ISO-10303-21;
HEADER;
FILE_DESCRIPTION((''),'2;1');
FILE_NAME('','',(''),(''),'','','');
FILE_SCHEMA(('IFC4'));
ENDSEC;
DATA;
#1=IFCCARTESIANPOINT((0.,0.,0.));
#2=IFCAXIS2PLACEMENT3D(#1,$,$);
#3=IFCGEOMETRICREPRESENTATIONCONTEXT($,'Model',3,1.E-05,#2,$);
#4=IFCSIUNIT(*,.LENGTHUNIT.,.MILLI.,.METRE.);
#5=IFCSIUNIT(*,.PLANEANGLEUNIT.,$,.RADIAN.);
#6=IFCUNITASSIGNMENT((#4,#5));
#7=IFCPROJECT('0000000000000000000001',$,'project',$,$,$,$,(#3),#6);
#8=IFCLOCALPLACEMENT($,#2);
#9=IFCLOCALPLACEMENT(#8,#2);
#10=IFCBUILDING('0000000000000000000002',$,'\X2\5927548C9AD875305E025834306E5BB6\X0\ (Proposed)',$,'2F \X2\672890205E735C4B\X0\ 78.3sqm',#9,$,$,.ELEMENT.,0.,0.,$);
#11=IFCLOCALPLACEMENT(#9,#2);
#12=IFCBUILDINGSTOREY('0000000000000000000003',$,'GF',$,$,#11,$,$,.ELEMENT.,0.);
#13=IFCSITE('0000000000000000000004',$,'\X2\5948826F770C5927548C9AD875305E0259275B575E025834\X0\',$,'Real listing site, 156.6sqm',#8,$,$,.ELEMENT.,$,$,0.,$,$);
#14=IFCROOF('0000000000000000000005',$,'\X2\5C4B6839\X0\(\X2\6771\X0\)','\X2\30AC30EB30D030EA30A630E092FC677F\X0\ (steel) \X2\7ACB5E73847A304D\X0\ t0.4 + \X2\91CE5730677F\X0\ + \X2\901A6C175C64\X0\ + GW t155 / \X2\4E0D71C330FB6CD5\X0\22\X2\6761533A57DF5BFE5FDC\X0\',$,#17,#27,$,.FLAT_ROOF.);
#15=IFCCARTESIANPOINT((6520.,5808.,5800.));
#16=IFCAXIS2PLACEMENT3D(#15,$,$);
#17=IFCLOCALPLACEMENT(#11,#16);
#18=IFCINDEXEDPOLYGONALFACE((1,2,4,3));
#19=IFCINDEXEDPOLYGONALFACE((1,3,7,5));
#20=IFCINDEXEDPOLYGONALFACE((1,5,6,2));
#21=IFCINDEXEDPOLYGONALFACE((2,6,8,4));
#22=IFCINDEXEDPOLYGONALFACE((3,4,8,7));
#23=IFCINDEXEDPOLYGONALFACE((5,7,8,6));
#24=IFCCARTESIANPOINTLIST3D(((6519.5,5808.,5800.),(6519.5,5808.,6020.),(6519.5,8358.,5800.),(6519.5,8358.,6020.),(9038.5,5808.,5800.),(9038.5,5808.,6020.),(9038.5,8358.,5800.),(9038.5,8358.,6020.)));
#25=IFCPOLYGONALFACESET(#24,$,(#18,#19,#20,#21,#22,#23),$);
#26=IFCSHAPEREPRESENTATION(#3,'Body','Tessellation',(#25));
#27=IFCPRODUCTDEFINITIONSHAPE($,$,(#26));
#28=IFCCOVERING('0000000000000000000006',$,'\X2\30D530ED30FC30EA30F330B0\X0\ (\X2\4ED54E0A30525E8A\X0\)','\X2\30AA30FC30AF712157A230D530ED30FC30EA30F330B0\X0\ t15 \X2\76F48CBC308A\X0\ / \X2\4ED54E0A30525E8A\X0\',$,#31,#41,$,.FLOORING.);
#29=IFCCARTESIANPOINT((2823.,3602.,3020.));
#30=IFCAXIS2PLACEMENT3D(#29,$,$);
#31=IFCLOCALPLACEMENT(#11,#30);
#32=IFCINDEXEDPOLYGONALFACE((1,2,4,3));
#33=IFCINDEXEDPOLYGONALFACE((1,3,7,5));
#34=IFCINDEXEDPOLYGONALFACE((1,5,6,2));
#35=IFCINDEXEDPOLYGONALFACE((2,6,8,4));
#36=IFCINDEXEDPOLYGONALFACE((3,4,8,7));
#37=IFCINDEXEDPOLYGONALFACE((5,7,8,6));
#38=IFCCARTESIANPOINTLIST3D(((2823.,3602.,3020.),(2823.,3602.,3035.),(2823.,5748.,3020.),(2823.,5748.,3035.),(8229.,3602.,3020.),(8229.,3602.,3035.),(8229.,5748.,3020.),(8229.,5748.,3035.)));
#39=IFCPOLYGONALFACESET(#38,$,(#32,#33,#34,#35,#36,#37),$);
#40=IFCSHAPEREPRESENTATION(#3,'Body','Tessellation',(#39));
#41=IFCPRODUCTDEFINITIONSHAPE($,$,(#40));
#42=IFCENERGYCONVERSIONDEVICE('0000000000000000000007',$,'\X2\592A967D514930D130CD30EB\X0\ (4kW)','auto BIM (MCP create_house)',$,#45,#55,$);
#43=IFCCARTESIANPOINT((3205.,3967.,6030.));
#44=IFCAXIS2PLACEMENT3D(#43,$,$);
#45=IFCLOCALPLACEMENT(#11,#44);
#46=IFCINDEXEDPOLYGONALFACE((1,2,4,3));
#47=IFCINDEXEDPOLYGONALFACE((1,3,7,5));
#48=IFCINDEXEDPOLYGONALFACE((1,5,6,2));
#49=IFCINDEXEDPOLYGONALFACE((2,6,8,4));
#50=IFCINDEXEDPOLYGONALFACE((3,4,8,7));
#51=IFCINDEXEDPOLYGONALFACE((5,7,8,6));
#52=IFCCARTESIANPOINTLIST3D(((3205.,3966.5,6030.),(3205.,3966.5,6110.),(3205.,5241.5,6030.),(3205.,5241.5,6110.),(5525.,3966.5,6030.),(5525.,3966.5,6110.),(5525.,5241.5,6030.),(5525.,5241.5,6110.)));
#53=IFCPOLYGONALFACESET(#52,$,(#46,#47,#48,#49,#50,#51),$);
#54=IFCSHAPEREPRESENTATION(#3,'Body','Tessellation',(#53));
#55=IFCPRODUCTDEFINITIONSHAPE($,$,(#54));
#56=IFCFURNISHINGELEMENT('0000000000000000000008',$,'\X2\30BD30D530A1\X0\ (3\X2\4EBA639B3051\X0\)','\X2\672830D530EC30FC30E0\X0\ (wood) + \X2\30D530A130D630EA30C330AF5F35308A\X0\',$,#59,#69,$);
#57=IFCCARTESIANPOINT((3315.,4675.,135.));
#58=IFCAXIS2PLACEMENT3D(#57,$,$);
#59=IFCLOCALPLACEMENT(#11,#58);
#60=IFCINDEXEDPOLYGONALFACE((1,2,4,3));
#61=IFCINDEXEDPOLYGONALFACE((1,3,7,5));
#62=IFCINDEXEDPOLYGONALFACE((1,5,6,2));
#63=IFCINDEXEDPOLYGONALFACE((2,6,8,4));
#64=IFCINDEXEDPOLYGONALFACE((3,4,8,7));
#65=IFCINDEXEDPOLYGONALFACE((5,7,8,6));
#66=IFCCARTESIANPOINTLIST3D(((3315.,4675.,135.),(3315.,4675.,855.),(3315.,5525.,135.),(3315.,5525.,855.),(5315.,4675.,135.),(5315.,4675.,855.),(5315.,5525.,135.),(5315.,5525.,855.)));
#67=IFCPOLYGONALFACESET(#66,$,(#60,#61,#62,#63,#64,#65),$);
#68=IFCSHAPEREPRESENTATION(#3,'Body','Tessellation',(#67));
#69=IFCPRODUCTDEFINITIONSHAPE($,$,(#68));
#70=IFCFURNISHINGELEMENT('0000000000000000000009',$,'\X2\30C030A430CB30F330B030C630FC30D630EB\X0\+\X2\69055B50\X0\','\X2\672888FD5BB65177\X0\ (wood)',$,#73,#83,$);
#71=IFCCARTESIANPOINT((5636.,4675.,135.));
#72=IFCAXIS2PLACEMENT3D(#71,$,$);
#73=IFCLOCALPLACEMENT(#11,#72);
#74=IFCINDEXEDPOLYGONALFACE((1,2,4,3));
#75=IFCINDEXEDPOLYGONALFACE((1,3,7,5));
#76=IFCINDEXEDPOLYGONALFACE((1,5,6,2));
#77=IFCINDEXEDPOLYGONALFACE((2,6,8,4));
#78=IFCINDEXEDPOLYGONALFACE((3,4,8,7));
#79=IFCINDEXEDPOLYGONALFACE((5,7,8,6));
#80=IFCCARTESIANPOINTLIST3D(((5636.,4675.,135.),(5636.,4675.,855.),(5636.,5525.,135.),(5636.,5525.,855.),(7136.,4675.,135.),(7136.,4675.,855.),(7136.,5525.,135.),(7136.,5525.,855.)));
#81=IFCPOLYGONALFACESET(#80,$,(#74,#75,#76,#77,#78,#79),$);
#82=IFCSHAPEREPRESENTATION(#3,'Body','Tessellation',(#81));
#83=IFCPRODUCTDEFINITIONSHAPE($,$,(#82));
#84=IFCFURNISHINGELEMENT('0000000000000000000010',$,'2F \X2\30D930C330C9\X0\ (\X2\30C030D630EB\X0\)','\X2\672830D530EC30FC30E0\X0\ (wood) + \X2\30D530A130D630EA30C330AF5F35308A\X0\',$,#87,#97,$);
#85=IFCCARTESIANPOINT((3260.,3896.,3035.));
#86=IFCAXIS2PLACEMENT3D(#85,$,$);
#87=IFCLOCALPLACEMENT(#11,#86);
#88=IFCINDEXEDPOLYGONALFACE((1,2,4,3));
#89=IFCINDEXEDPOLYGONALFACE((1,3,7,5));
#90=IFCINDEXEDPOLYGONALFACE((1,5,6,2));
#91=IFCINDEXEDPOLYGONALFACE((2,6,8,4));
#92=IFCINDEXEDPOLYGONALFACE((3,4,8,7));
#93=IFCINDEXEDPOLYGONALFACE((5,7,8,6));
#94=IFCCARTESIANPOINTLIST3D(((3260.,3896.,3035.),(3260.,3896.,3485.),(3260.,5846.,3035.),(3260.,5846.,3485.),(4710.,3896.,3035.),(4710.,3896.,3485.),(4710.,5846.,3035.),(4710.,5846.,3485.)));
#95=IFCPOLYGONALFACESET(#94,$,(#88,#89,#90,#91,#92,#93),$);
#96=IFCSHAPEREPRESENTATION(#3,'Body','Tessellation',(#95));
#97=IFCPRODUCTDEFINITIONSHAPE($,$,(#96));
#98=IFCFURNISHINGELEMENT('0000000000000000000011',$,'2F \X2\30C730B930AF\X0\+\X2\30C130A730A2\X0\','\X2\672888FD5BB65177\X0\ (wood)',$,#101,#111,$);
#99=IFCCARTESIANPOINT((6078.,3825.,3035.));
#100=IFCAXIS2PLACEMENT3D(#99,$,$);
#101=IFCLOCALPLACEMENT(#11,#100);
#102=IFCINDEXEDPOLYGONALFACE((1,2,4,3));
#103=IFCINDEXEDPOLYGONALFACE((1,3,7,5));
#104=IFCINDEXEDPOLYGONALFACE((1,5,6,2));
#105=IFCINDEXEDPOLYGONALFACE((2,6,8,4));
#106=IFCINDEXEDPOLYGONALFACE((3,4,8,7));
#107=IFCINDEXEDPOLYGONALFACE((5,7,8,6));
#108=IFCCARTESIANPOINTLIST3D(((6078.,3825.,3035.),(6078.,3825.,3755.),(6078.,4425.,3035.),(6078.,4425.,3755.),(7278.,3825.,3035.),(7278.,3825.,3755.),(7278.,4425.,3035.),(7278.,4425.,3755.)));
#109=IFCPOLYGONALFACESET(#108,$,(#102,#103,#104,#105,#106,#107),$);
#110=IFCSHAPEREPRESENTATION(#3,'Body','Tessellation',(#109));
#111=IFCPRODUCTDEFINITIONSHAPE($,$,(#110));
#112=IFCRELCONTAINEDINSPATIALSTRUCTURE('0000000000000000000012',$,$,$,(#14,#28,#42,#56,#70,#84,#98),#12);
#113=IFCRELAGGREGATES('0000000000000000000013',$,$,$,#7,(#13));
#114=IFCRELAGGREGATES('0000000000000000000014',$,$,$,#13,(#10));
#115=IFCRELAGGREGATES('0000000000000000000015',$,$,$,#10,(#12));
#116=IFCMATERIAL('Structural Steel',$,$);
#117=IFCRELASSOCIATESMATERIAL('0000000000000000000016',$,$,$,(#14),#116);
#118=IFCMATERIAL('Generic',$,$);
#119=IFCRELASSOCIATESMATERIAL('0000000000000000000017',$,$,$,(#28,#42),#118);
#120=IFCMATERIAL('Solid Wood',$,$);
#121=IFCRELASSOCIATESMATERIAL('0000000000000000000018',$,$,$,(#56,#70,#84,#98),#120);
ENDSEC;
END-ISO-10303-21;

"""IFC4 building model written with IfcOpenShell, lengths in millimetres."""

from ifc_helpers import new_model, si_unit, frame, frame_2d, origin, place, context, project, spatial, rectangle, extrude, material, element, save


model = new_model("IFC4")

# Units and contexts
model_context = context("Model", 3, precision=1e-05, world=origin())
ifc_project = project(units=[si_unit("LENGTHUNIT", "METRE", prefix="MILLI"), si_unit("PLANEANGLEUNIT", "RADIAN")], contexts=[model_context])

# Site, building, storey
site_placement = place(None, origin())
site = spatial("IfcSite", under=ifc_project, at=site_placement, Name="奈良県大和高田市大字市場", ObjectType="Real listing site, 156.6sqm", CompositionType="ELEMENT", RefElevation=0.0)
building_placement = place(site_placement, origin())
building = spatial("IfcBuilding", under=site, at=building_placement, Name="大和高田市場の家 (Proposed)", ObjectType="2F 木造平屋 78.3sqm", CompositionType="ELEMENT", ElevationOfRefHeight=0.0, ElevationOfTerrain=0.0)
storey_placement = place(building_placement, origin())
storey = spatial("IfcBuildingStorey", under=building, at=storey_placement, Name="GF", CompositionType="ELEMENT", Elevation=0.0)

# Shared definitions
ifc_material_1 = material(Name="Solid Wood")

# Roof
ifc_material_2 = material(Name="Structural Steel")
roof_1_placement = place(storey_placement, frame((6520.0, 5808.0, 5800.0)))
element("IfcRoof", 1, at=roof_1_placement, inside=storey, material=ifc_material_2, Name="屋根(東)", Description="ガルバリウム鋼板 (steel) 立平葺き t0.4 + 野地板 + 通気層 + GW t155 / 不燃・法22条区域対応", PredefinedType="FLAT_ROOF", context=model_context, shape_type="SweptSolid", body=[
    extrude(rectangle(XDim=2519.0, YDim=2550.0, at=frame_2d((1259.0, 1275.0))), frame((6520.0, 5808.0, 5800.0)), (0.0, 0.0, 1.0), 220.0),
])

# Covering
ifc_material_3 = material(Name="Generic")
covering_placement = place(storey_placement, frame((2823.0, 3602.0, 3020.0)))
element("IfcCovering", 2, at=covering_placement, inside=storey, material=ifc_material_3, Name="フローリング (仕上げ床)", Description="オーク無垢フローリング t15 直貼り / 仕上げ床", PredefinedType="FLOORING", context=model_context, shape_type="SweptSolid", body=[
    extrude(rectangle(XDim=5406.0, YDim=2146.0, at=frame_2d((2703.0, 1073.0))), frame((2823.0, 3602.0, 3020.0)), (0.0, 0.0, 1.0), 15.0),
])

# Energy conversion device
energy_conversion_device_placement = place(storey_placement, frame((3205.0, 3967.0, 6030.0)))
element("IfcEnergyConversionDevice", 3, at=energy_conversion_device_placement, inside=storey, material=ifc_material_3, Name="太陽光パネル (4kW)", Description="auto BIM (MCP create_house)", context=model_context, shape_type="SweptSolid", body=[
    extrude(rectangle(XDim=2320.0, YDim=1275.0, at=frame_2d((1160.0, 637.0))), frame((3205.0, 3967.0, 6030.0)), (0.0, 0.0, 1.0), 80.0),
])

# Furnishing elements
furnishing_1_placement = place(storey_placement, frame((3315.0, 4675.0, 135.0)))
element("IfcFurnishingElement", 4, at=furnishing_1_placement, inside=storey, material=ifc_material_1, Name="ソファ (3人掛け)", Description="木フレーム (wood) + ファブリック張り", context=model_context, shape_type="SweptSolid", body=[
    extrude(rectangle(XDim=2000.0, YDim=850.0, at=frame_2d((1000.0, 425.0))), frame((3315.0, 4675.0, 135.0)), (0.0, 0.0, 1.0), 720.0),
])
furnishing_2_placement = place(storey_placement, frame((5636.0, 4675.0, 135.0)))
element("IfcFurnishingElement", 5, at=furnishing_2_placement, inside=storey, material=ifc_material_1, Name="ダイニングテーブル+椅子", Description="木製家具 (wood)", context=model_context, shape_type="SweptSolid", body=[
    extrude(rectangle(XDim=1500.0, YDim=850.0, at=frame_2d((750.0, 425.0))), frame((5636.0, 4675.0, 135.0)), (0.0, 0.0, 1.0), 720.0),
])
furnishing_3_placement = place(storey_placement, frame((3260.0, 3896.0, 3035.0)))
element("IfcFurnishingElement", 6, at=furnishing_3_placement, inside=storey, material=ifc_material_1, Name="2F ベッド (ダブル)", Description="木フレーム (wood) + ファブリック張り", context=model_context, shape_type="SweptSolid", body=[
    extrude(rectangle(XDim=1450.0, YDim=1950.0, at=frame_2d((725.0, 975.0))), frame((3260.0, 3896.0, 3035.0)), (0.0, 0.0, 1.0), 450.0),
])
furnishing_4_placement = place(storey_placement, frame((6078.0, 3825.0, 3035.0)))
element("IfcFurnishingElement", 7, at=furnishing_4_placement, inside=storey, material=ifc_material_1, Name="2F デスク+チェア", Description="木製家具 (wood)", context=model_context, shape_type="SweptSolid", body=[
    extrude(rectangle(XDim=1200.0, YDim=600.0, at=frame_2d((600.0, 300.0))), frame((6078.0, 3825.0, 3035.0)), (0.0, 0.0, 1.0), 720.0),
])

save(model, "model.ifc")
